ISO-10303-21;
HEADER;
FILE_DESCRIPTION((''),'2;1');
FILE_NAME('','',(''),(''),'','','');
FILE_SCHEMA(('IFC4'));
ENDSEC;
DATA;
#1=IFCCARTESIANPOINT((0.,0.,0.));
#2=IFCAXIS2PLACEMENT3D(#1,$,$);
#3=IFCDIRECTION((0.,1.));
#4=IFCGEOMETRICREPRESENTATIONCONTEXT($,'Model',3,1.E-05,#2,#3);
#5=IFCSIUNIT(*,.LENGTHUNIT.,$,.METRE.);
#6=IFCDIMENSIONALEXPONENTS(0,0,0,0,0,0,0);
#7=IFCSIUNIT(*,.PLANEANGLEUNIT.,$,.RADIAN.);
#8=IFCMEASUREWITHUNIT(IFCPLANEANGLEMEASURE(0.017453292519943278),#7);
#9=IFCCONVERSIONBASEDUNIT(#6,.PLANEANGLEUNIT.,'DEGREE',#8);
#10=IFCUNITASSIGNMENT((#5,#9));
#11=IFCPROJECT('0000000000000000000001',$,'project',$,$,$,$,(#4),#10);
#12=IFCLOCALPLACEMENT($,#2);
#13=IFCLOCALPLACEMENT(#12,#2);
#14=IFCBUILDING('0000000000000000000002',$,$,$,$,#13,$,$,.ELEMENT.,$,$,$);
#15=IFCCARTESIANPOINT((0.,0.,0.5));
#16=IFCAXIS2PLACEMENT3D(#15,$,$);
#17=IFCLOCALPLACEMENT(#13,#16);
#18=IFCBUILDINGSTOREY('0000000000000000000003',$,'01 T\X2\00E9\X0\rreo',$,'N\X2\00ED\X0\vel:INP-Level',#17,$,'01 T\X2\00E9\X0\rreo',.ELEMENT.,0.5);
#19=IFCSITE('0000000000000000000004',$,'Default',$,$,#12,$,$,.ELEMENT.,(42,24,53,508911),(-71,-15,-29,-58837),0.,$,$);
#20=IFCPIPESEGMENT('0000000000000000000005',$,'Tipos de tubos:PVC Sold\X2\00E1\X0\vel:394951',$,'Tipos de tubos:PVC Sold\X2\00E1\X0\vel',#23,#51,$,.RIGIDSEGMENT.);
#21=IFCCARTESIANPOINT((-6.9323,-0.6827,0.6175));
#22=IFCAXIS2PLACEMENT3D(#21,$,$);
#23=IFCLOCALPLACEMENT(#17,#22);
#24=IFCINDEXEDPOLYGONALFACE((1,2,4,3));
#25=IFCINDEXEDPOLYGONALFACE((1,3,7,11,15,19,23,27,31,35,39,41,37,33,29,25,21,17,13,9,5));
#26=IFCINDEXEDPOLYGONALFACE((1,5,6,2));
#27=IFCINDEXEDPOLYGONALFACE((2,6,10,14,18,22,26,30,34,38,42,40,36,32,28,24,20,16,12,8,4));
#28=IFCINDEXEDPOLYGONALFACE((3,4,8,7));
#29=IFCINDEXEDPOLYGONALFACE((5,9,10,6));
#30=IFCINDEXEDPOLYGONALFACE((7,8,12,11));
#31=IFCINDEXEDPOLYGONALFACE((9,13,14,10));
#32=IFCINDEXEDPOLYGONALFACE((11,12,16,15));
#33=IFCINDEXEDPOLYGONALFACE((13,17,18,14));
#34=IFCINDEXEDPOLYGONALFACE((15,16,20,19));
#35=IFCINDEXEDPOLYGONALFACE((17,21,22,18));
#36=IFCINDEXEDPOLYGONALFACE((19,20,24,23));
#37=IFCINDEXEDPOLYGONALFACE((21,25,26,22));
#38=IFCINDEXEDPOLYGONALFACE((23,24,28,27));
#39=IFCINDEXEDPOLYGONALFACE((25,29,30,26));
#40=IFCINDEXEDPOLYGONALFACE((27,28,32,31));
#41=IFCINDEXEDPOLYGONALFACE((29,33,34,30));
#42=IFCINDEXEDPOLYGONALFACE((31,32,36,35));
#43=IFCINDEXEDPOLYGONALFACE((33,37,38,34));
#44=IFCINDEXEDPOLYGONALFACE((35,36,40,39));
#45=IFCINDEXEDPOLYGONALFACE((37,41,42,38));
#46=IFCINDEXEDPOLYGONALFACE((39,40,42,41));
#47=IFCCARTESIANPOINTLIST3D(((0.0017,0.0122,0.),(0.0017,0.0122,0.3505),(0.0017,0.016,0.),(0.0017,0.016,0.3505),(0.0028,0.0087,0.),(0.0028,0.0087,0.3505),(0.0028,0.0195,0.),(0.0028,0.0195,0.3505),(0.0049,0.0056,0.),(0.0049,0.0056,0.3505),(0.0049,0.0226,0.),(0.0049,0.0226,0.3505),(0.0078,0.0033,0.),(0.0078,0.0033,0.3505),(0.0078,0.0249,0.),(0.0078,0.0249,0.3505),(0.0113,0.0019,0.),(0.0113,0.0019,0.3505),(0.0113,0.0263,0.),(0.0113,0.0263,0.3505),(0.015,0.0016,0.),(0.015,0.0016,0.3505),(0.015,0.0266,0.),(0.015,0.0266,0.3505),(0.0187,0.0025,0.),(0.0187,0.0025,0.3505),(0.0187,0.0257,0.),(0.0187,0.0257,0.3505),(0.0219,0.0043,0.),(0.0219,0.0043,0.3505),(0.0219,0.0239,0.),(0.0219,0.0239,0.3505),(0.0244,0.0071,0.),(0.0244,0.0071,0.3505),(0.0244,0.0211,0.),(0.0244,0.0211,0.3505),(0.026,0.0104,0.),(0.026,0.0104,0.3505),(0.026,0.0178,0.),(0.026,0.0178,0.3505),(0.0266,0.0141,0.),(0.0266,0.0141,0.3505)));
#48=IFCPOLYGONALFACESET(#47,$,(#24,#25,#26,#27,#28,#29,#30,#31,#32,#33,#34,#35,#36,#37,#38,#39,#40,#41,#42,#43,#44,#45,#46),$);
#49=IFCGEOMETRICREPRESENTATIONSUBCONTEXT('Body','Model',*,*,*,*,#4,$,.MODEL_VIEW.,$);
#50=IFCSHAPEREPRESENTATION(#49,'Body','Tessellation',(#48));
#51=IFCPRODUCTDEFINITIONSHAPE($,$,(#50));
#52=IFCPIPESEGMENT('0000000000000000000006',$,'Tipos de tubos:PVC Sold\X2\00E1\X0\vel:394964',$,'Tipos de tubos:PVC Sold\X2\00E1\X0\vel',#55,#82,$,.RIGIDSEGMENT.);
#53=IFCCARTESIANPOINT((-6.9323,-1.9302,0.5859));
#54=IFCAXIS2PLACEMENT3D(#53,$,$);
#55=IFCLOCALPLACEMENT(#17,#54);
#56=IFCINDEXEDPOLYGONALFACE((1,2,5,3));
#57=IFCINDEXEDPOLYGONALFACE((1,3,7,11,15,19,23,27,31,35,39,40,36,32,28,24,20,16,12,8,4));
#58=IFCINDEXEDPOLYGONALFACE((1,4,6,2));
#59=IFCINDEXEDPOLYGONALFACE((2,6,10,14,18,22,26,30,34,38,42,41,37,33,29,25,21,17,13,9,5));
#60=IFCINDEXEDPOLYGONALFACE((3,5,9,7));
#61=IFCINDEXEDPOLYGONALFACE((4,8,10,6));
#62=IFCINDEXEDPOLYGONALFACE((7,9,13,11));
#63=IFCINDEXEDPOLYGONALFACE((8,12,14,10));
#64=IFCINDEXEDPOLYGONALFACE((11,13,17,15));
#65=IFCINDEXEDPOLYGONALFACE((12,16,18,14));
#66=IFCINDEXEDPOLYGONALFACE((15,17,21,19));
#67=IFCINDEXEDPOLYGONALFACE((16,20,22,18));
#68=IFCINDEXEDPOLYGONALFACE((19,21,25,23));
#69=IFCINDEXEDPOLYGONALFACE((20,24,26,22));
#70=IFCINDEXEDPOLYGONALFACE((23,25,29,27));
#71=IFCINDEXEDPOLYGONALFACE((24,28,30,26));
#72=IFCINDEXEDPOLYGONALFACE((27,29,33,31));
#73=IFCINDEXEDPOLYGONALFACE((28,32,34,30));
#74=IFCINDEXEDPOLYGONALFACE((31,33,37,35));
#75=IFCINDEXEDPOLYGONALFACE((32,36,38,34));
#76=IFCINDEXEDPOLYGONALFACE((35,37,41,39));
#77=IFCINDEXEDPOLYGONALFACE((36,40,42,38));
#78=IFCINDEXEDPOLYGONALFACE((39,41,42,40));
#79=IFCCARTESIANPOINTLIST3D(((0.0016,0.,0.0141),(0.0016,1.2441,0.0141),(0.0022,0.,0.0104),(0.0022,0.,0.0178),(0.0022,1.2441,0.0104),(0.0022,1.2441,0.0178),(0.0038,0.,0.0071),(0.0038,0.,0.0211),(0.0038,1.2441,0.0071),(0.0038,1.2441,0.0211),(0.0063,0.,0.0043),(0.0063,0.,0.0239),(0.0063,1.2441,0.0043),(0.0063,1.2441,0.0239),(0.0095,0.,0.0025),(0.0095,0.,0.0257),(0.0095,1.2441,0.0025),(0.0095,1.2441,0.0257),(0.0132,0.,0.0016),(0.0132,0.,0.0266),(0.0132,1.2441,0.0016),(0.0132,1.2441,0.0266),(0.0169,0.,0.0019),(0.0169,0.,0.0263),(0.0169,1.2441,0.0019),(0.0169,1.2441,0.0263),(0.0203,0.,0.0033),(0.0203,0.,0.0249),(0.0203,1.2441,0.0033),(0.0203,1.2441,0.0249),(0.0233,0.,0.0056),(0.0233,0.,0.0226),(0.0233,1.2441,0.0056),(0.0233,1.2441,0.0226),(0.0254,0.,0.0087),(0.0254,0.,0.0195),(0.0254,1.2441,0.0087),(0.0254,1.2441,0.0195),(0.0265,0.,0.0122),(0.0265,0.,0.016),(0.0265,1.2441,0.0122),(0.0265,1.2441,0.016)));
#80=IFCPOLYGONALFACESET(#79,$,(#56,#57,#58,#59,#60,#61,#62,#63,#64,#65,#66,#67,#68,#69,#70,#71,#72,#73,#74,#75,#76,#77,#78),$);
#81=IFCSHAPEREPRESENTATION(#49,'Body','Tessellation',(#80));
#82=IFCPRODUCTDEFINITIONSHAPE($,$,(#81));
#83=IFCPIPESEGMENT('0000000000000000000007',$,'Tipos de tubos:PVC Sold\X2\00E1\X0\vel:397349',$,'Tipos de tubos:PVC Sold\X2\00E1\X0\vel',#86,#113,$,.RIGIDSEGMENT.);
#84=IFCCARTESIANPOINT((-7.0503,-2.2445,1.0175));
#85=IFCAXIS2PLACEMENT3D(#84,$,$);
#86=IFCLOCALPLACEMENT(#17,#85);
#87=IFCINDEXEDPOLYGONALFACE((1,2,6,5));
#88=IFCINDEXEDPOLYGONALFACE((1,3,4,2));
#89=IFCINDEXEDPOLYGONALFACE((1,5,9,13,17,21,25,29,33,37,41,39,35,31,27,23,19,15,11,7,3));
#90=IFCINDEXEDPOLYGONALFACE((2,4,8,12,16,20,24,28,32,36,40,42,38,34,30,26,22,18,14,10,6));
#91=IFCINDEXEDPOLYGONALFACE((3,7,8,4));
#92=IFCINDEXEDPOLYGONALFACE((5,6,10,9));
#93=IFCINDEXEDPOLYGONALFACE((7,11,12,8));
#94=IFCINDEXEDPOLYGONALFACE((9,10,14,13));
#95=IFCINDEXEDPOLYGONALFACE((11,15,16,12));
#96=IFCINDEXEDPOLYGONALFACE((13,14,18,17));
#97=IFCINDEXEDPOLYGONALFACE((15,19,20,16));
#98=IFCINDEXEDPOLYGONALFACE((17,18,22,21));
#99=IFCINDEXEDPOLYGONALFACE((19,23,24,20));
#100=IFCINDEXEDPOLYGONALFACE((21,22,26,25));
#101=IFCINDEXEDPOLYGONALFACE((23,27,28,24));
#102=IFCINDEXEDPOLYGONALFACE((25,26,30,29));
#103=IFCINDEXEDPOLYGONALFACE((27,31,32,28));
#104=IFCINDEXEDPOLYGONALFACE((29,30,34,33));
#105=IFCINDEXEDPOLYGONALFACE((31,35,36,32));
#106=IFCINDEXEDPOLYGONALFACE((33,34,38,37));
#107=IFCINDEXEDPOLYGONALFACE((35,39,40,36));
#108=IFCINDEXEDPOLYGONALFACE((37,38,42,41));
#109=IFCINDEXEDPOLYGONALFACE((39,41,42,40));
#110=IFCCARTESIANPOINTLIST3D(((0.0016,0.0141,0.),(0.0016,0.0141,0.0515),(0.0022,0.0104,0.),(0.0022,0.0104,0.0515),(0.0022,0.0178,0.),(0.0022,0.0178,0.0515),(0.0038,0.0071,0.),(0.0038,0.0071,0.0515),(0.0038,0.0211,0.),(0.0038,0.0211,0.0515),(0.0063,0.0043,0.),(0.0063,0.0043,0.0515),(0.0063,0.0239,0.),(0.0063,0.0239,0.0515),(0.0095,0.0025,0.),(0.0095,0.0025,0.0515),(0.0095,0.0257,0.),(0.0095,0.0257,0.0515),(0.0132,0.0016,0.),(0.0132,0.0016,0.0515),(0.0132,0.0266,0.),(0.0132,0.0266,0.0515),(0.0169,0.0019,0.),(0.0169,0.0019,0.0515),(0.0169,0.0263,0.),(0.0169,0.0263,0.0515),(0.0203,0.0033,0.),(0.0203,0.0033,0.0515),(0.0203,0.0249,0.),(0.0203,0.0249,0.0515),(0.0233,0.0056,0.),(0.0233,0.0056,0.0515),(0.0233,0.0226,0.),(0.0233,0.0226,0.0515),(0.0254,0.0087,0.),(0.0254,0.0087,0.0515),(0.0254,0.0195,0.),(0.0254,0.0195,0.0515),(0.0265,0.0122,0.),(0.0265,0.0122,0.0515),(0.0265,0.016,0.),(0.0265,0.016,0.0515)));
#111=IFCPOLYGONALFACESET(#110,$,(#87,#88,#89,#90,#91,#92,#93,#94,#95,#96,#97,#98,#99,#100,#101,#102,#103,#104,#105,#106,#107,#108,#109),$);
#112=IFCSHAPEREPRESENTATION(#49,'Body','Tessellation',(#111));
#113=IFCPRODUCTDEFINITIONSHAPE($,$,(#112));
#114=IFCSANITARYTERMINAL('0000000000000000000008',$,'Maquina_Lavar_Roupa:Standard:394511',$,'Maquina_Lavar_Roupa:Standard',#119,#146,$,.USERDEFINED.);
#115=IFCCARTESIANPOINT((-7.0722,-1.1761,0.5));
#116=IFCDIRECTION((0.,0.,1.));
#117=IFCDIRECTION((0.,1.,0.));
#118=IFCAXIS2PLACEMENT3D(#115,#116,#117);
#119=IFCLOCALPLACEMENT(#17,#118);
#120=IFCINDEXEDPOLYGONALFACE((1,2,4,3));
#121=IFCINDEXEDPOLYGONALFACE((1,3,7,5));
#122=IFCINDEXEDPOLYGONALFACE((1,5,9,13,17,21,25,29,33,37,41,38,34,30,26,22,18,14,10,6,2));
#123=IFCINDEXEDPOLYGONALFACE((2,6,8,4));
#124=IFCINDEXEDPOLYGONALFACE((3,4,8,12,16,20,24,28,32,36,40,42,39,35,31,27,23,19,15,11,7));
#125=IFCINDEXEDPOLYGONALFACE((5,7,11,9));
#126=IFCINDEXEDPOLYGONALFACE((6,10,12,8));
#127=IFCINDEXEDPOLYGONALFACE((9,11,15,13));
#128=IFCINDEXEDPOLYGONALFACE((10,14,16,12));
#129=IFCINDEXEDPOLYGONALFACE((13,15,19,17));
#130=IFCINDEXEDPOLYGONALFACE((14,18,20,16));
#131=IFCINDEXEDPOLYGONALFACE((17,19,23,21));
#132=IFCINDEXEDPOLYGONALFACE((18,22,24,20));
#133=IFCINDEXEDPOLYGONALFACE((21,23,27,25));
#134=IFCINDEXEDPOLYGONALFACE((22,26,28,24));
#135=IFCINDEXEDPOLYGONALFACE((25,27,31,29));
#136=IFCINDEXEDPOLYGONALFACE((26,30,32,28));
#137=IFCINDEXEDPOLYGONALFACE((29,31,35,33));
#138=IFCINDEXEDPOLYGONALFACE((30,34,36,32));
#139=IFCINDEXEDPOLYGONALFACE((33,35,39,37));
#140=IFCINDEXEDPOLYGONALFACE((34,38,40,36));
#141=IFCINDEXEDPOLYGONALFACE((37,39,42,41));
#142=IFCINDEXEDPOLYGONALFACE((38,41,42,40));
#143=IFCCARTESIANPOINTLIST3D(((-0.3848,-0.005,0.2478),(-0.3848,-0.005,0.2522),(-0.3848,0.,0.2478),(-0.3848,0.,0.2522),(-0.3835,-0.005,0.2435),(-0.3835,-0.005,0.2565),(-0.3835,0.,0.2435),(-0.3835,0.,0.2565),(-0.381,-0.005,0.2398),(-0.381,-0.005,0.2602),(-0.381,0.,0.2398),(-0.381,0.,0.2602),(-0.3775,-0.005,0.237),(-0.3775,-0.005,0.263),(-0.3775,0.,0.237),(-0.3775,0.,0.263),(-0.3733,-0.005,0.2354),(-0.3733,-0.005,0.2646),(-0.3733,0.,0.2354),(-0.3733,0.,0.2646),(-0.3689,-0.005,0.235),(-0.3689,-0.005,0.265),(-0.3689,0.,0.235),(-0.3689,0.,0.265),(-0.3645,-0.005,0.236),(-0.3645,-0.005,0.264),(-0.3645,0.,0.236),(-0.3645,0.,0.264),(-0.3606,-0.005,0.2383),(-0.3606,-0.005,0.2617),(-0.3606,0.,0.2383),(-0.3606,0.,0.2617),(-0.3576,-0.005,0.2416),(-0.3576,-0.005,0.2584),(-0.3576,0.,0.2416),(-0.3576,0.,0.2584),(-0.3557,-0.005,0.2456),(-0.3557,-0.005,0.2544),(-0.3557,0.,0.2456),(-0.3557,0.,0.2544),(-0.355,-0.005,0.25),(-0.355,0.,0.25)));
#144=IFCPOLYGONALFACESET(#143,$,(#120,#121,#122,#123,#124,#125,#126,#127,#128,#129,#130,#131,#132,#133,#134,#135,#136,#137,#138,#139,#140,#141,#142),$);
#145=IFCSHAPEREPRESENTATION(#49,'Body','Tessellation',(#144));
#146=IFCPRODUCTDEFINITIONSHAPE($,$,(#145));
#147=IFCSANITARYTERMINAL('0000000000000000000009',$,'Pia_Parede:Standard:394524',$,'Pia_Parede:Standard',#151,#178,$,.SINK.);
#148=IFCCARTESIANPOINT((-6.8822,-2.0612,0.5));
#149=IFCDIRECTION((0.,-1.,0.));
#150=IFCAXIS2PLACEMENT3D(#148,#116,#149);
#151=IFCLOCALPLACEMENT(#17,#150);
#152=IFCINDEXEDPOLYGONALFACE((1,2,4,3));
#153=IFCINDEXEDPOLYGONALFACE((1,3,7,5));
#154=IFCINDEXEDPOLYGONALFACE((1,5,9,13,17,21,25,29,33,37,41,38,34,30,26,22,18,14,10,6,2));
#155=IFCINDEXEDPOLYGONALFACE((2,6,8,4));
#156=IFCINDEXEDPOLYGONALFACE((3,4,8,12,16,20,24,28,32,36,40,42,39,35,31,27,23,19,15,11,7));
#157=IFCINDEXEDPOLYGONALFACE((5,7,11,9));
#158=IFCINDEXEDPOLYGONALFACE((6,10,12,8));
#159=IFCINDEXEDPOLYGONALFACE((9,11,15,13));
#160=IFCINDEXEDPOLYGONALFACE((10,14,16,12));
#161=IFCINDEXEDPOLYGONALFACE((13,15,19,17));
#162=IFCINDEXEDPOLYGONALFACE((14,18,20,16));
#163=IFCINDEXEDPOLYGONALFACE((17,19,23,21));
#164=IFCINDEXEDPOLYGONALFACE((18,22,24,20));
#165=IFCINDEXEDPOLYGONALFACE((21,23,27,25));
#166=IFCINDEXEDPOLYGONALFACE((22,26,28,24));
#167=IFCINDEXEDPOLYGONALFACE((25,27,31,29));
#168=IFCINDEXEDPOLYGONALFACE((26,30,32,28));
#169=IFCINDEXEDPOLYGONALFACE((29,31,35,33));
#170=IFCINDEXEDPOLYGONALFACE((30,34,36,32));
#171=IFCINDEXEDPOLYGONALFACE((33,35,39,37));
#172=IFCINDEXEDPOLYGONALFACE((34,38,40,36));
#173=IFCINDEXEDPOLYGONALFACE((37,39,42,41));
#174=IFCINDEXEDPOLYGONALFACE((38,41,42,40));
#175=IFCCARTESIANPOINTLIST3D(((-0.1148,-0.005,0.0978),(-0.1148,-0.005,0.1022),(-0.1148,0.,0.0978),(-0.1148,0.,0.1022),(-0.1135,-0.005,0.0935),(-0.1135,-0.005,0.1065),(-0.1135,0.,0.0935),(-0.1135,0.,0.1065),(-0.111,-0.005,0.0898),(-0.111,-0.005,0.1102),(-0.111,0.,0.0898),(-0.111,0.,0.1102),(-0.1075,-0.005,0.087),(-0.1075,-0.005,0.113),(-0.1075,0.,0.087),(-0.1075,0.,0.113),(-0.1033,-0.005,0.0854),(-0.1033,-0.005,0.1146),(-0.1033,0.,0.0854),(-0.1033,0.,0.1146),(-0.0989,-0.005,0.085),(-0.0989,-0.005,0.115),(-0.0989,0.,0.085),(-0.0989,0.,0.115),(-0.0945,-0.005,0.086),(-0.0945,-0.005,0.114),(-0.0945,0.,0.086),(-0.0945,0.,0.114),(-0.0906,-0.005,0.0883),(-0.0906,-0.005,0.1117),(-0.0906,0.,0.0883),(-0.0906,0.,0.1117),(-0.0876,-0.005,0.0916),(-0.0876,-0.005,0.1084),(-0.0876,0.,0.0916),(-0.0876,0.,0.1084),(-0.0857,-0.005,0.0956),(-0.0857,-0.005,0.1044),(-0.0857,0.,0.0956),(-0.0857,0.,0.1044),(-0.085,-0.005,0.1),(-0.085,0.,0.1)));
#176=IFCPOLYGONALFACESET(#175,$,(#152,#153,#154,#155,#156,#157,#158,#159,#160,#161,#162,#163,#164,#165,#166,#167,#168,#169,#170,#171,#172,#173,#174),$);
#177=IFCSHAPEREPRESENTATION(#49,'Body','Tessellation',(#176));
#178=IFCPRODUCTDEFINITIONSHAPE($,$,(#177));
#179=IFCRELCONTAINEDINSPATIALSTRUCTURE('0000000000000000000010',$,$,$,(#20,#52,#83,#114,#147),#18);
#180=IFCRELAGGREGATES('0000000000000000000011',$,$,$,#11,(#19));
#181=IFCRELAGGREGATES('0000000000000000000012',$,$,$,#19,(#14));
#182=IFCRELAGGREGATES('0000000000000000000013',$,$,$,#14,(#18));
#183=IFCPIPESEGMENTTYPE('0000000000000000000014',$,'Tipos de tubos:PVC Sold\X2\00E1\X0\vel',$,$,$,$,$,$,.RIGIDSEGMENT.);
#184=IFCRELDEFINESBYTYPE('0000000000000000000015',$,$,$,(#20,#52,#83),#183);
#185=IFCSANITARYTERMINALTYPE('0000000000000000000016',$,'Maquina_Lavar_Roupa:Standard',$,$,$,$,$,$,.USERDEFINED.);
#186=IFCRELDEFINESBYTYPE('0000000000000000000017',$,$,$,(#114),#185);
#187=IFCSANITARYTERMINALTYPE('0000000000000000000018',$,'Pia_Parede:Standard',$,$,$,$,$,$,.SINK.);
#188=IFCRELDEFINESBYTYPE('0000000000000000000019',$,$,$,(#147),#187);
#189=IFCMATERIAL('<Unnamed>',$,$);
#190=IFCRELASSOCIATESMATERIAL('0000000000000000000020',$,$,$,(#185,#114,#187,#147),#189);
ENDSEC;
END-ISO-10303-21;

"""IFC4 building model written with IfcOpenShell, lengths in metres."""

from ifc_helpers import new_model, entity, si_unit, converted_unit, direction, frame, frame_2d, origin, origin_2d_with_axis, place, context, subcontext, project, spatial, circle, extrude, source, transform, mapped, material, type_object, type_shapes, element, save


model = new_model("IFC4")

# Units and contexts
model_context = context("Model", 3, precision=1e-05, world=origin(), true_north=direction((0.0, 1.0)))
body_context = subcontext(model_context, "Body", "Model", "MODEL_VIEW")
ifc_project = project(units=[si_unit("LENGTHUNIT", "METRE"), converted_unit("PLANEANGLEUNIT", "DEGREE", entity("IfcPlaneAngleMeasure", 0.017453292519943278), si_unit("PLANEANGLEUNIT", "RADIAN"), dimensions=[0, 0, 0, 0, 0, 0, 0])], contexts=[model_context])

# Site, building, storey
site_placement = place(None, origin())
site = spatial("IfcSite", under=ifc_project, at=site_placement, Name="Default", CompositionType="ELEMENT", RefLatitude=(42, 24, 53, 508911), RefLongitude=(-71, -15, -29, -58837), RefElevation=0.0)
building_placement = place(site_placement, origin())
building = spatial("IfcBuilding", under=site, at=building_placement, CompositionType="ELEMENT")
storey_placement = place(building_placement, frame((0.0, 0.0, 0.5)))
storey = spatial("IfcBuildingStorey", under=building, at=storey_placement, Name="01 Térreo", ObjectType="Nível:INP-Level", LongName="01 Térreo", CompositionType="ELEMENT", Elevation=0.5)

# Pipe segments
pipe_segment_type = type_object("IfcPipeSegmentType", Name="Tipos de tubos:PVC Soldável", PredefinedType="RIGIDSEGMENT")
pipe_segment_1_placement = place(storey_placement, frame((-6.9323, -0.6827, 0.6175)))
element("IfcPipeSegment", 1, at=pipe_segment_1_placement, inside=storey, type_object=pipe_segment_type, Name="Tipos de tubos:PVC Soldável:394951", ObjectType="Tipos de tubos:PVC Soldável", PredefinedType="RIGIDSEGMENT", context=body_context, shape_type="SweptSolid", body=[
    extrude(circle(Radius=0.0125, at=origin_2d_with_axis()), frame((0.0141, 0.0141, 0.0)), (0.0, 0.0, 1.0), 0.3505),
])
pipe_segment_2_placement = place(storey_placement, frame((-6.9323, -1.9302, 0.5859)))
element("IfcPipeSegment", 2, at=pipe_segment_2_placement, inside=storey, type_object=pipe_segment_type, Name="Tipos de tubos:PVC Soldável:394964", ObjectType="Tipos de tubos:PVC Soldável", PredefinedType="RIGIDSEGMENT", context=body_context, shape_type="SweptSolid", body=[
    extrude(circle(Radius=0.0125, at=frame_2d((0.0, 0.0), x_axis=(1.0, 0.0))), frame((0.0141, 0.0, 0.0141), z_axis=(0.0, 1.0, 0.0), x_axis=(-1.0, 0.0, 0.0)), (0.0, 0.0, 1.0), 1.2441),
])
pipe_segment_3_placement = place(storey_placement, frame((-7.0503, -2.2445, 1.0175)))
element("IfcPipeSegment", 3, at=pipe_segment_3_placement, inside=storey, type_object=pipe_segment_type, Name="Tipos de tubos:PVC Soldável:397349", ObjectType="Tipos de tubos:PVC Soldável", PredefinedType="RIGIDSEGMENT", context=body_context, shape_type="SweptSolid", body=[
    extrude(circle(Radius=0.0125, at=frame_2d((0.0, 0.0), x_axis=(1.0, 0.0))), frame((0.0141, 0.0141, 0.0), z_axis=(0.0, 0.0, 1.0), x_axis=(-1.0, 0.0, 0.0)), (0.0, 0.0, 1.0), 0.0515),
])

# Sanitary terminals
ifc_material = material(Name="<Unnamed>")
sanitary_terminal_type_1 = type_object("IfcSanitaryTerminalType", Name="Maquina_Lavar_Roupa:Standard", PredefinedType="USERDEFINED", material=ifc_material)
shared_shape_1 = source(origin(), body_context, "Body", "SweptSolid", [
    extrude(circle(Radius=0.015, at=frame_2d((0.0, 0.0), x_axis=(1.0, 0.0))), frame((-0.37, -0.005, 0.25), z_axis=(0.0, 1.0, 0.0), x_axis=(1.0, 0.0, 0.0)), (0.0, 0.0, 1.0), 0.005),
])
type_shapes(sanitary_terminal_type_1, [shared_shape_1])
sanitary_terminal_1_placement = place(storey_placement, frame((-7.0722, -1.1761, 0.5), z_axis=(0.0, 0.0, 1.0), x_axis=(0.0, 1.0, 0.0)))
element("IfcSanitaryTerminal", 4, at=sanitary_terminal_1_placement, inside=storey, type_object=sanitary_terminal_type_1, material=ifc_material, Name="Maquina_Lavar_Roupa:Standard:394511", ObjectType="Maquina_Lavar_Roupa:Standard", PredefinedType="USERDEFINED", context=body_context, shape_type="MappedRepresentation", body=[
    mapped(shared_shape_1, transform((0.0, 0.0, 0.0), scale=1.0)),
])
sanitary_terminal_type_2 = type_object("IfcSanitaryTerminalType", Name="Pia_Parede:Standard", PredefinedType="SINK", material=ifc_material)
shared_shape_2 = source(origin(), body_context, "Body", "SweptSolid", [
    extrude(circle(Radius=0.015, at=origin_2d_with_axis()), frame((-0.1, -0.005, 0.1), z_axis=(0.0, 1.0, 0.0), x_axis=(1.0, 0.0, 0.0)), (0.0, 0.0, 1.0), 0.005),
])
type_shapes(sanitary_terminal_type_2, [shared_shape_2])
sanitary_terminal_2_placement = place(storey_placement, frame((-6.8822, -2.0612, 0.5), z_axis=(0.0, 0.0, 1.0), x_axis=(0.0, -1.0, 0.0)))
element("IfcSanitaryTerminal", 5, at=sanitary_terminal_2_placement, inside=storey, type_object=sanitary_terminal_type_2, material=ifc_material, Name="Pia_Parede:Standard:394524", ObjectType="Pia_Parede:Standard", PredefinedType="SINK", context=body_context, shape_type="MappedRepresentation", body=[
    mapped(shared_shape_2, transform((0.0, 0.0, 0.0), scale=1.0)),
])

save(model, "model.ifc")
